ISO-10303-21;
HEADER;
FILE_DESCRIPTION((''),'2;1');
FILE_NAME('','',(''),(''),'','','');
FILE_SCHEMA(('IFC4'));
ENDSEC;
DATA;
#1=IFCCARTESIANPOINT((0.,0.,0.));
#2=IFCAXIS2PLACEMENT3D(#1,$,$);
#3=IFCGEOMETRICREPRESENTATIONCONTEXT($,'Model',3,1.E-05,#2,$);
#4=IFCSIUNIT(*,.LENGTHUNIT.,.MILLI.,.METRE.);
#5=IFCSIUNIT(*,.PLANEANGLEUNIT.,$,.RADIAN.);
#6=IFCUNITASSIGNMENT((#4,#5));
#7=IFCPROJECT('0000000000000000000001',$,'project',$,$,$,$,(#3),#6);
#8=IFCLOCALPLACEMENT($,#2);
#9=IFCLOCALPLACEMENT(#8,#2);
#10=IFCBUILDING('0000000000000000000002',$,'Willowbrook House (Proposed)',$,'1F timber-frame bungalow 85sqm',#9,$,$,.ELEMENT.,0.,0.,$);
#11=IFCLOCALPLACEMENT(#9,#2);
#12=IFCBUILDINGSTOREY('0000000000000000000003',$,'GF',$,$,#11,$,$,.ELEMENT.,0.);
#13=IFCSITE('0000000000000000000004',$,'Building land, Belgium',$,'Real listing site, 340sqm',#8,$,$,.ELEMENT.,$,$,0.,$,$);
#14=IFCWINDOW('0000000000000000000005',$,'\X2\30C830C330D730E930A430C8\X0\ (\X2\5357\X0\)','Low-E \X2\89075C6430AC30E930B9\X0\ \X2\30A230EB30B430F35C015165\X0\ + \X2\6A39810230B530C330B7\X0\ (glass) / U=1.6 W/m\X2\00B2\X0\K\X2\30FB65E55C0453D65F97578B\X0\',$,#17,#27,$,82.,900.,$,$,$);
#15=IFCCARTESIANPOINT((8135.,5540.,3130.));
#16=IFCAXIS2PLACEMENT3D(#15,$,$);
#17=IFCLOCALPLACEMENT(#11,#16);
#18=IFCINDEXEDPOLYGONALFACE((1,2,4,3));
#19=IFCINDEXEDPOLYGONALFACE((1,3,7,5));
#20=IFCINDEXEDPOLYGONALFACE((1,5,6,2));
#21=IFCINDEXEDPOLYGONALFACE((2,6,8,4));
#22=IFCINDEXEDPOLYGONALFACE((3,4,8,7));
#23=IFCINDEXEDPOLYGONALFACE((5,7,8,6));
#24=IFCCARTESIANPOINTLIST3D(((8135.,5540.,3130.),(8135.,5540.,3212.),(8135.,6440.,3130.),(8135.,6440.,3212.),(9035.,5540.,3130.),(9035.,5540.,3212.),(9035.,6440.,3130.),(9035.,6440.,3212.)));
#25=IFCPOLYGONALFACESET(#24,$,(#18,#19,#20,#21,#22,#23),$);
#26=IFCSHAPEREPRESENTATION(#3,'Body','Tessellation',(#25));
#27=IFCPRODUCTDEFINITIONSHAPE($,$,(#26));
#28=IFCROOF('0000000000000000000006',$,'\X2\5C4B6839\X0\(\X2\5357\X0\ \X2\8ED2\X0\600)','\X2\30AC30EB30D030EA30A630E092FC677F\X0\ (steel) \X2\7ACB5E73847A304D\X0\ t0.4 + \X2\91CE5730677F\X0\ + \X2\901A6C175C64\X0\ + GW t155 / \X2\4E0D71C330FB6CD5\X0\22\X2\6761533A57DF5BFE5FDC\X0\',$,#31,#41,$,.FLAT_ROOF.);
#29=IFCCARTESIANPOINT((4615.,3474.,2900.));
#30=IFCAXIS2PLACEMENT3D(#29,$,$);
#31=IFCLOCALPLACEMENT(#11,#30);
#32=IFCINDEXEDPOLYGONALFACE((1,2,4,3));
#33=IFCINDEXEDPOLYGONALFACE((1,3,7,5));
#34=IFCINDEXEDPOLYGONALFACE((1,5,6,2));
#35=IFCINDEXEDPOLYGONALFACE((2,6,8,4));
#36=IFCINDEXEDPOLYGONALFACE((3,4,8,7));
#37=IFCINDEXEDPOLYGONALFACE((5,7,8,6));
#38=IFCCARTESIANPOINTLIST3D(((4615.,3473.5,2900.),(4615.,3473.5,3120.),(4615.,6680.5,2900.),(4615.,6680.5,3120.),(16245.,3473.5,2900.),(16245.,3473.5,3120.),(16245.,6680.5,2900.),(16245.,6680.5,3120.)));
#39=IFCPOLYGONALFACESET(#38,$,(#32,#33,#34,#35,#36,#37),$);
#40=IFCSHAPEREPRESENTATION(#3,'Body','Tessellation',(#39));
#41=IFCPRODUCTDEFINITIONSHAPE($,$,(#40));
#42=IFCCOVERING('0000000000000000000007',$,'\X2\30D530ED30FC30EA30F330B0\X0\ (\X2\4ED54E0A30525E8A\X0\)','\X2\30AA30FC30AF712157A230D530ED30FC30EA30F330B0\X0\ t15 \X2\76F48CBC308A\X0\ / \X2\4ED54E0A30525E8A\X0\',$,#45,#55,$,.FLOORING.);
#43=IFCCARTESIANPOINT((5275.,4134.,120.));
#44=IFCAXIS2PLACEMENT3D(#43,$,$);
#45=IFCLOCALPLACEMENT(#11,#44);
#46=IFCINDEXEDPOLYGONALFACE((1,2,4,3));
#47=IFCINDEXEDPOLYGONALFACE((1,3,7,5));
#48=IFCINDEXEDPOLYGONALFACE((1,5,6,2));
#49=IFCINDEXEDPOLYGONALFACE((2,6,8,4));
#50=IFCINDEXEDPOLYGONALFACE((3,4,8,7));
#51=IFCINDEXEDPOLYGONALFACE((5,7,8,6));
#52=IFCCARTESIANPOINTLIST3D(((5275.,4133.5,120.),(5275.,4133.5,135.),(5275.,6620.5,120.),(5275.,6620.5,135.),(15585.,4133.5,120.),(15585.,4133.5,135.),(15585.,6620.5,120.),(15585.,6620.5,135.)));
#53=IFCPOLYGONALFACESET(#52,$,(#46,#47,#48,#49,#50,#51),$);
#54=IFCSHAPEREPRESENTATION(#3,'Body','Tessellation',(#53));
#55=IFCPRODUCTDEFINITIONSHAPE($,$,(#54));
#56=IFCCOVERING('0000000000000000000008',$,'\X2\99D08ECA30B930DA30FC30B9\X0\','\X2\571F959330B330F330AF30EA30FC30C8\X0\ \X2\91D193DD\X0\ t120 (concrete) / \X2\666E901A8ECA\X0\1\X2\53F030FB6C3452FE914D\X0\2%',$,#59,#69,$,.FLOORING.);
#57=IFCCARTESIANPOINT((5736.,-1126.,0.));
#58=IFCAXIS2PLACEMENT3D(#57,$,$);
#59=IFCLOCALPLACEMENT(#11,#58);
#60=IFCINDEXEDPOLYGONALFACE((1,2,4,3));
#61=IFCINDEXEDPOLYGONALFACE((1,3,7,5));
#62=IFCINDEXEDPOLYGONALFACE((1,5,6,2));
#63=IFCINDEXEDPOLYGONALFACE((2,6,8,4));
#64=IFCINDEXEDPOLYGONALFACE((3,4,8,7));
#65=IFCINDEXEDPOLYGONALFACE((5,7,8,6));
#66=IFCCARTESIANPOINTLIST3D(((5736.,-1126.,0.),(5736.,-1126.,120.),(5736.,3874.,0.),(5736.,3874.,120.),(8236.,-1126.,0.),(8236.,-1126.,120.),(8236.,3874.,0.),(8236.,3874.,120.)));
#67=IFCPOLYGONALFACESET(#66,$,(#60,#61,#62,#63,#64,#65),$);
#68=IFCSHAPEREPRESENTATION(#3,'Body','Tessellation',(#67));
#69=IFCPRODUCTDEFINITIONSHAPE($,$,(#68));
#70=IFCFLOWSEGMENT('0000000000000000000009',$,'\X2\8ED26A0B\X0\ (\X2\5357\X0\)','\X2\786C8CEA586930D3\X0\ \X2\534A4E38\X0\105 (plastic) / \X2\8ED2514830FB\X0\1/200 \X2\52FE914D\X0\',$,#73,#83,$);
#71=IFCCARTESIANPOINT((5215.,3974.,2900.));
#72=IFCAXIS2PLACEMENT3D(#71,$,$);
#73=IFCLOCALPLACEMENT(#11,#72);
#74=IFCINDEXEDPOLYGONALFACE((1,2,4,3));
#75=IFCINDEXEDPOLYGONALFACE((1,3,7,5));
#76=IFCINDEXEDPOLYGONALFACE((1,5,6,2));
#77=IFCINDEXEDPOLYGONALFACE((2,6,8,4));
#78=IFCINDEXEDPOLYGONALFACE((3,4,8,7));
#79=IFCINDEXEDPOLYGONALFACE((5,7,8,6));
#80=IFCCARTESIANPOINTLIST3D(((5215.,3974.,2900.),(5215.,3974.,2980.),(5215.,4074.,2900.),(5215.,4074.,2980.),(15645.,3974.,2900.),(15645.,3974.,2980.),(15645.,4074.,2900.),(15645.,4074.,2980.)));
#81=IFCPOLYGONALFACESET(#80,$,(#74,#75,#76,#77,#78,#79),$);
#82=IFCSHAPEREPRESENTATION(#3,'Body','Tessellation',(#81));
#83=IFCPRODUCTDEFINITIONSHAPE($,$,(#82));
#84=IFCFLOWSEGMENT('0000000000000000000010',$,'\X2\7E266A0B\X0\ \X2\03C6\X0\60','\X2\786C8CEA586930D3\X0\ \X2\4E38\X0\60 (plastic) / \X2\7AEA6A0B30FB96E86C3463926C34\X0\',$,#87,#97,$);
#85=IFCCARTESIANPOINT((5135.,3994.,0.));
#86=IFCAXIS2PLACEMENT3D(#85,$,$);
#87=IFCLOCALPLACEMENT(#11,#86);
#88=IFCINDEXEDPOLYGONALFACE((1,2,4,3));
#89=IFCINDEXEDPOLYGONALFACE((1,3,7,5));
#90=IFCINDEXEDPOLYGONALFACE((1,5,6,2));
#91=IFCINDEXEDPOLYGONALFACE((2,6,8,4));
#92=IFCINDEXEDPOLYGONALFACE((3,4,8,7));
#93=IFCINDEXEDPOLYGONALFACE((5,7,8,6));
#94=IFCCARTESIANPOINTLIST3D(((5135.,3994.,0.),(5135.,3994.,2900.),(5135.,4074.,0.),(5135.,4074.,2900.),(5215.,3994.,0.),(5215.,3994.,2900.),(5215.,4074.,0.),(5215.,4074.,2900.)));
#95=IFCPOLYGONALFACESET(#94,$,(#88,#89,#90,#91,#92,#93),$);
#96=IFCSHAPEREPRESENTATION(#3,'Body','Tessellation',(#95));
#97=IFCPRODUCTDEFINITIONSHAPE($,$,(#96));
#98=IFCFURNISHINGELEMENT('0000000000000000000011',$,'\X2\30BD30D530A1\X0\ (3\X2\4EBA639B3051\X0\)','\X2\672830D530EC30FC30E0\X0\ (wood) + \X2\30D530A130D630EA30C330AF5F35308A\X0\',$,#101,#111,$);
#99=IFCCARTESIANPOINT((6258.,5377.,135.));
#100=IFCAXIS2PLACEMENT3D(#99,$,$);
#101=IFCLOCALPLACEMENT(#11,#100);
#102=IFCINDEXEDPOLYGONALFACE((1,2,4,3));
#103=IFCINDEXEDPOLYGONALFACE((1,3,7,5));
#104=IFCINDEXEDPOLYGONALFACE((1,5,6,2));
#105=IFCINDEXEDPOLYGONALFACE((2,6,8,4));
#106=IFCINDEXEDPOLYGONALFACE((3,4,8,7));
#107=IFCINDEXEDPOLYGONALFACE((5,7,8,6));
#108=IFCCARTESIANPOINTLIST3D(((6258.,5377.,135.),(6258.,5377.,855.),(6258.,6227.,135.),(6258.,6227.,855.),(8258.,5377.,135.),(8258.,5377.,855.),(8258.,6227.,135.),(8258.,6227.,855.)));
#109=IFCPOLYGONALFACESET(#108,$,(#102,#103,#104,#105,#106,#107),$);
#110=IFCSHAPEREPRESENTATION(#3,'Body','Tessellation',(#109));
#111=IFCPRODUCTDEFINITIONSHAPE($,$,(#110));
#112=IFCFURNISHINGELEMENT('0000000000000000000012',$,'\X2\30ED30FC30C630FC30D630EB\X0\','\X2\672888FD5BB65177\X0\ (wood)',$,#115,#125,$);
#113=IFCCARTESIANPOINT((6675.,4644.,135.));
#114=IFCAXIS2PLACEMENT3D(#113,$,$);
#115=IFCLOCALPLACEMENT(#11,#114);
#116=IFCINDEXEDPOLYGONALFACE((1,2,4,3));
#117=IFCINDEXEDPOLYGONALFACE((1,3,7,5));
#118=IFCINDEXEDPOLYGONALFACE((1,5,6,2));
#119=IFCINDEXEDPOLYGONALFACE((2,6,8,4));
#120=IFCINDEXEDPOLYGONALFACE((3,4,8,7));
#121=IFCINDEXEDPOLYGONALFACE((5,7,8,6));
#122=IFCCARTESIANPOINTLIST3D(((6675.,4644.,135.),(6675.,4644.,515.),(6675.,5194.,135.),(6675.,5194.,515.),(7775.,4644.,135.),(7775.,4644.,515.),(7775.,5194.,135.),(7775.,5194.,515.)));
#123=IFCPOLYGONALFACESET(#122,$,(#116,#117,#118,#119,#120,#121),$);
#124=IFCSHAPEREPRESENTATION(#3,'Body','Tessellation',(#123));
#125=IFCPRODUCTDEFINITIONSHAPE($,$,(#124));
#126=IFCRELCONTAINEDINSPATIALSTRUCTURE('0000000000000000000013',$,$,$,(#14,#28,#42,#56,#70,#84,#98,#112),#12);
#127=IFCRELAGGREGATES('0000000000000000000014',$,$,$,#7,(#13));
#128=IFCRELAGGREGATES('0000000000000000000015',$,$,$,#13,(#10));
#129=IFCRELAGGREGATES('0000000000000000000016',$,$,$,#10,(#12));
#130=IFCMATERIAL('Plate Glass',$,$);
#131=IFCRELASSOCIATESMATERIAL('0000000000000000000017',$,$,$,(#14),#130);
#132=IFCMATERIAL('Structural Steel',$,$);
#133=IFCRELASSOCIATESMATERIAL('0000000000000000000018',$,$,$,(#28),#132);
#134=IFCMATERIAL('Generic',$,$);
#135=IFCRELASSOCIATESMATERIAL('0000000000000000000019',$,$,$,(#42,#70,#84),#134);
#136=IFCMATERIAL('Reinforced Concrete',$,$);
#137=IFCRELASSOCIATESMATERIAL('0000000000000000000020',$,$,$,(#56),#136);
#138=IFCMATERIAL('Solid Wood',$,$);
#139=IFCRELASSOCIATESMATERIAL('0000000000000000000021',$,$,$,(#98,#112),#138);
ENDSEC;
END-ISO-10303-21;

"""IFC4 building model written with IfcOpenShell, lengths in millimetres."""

from ifc_helpers import new_model, si_unit, frame, frame_2d, origin, place, context, project, spatial, rectangle, extrude, material, element, save


model = new_model("IFC4")

# Units and contexts
model_context = context("Model", 3, precision=1e-05, world=origin())
ifc_project = project(units=[si_unit("LENGTHUNIT", "METRE", prefix="MILLI"), si_unit("PLANEANGLEUNIT", "RADIAN")], contexts=[model_context])

# Site, building, storey
site_placement = place(None, origin())
site = spatial("IfcSite", under=ifc_project, at=site_placement, Name="Building land, Belgium", ObjectType="Real listing site, 340sqm", CompositionType="ELEMENT", RefElevation=0.0)
building_placement = place(site_placement, origin())
building = spatial("IfcBuilding", under=site, at=building_placement, Name="Willowbrook House (Proposed)", ObjectType="1F timber-frame bungalow 85sqm", CompositionType="ELEMENT", ElevationOfRefHeight=0.0, ElevationOfTerrain=0.0)
storey_placement = place(building_placement, origin())
storey = spatial("IfcBuildingStorey", under=building, at=storey_placement, Name="GF", CompositionType="ELEMENT", Elevation=0.0)

# Shared definitions
ifc_material_1 = material(Name="Solid Wood")

# Shared definitions
ifc_material_2 = material(Name="Reinforced Concrete")

# Shared definitions
ifc_material_3 = material(Name="Plate Glass")

# Window
window_1_placement = place(storey_placement, frame((8135.0, 5540.0, 3130.0)))
element("IfcWindow", 1, at=window_1_placement, inside=storey, material=ifc_material_3, Name="トップライト (南)", Description="Low-E 複層ガラス アルゴン封入 + 樹脂サッシ (glass) / U=1.6 W/m²K・日射取得型", OverallHeight=82.0, OverallWidth=900.0, context=model_context, shape_type="SweptSolid", body=[
    extrude(rectangle(XDim=900.0, YDim=900.0, at=frame_2d((450.0, 450.0))), frame((8135.0, 5540.0, 3130.0)), (0.0, 0.0, 1.0), 82.0),
])

# Roof
ifc_material_4 = material(Name="Structural Steel")
roof_1_placement = place(storey_placement, frame((4615.0, 3474.0, 2900.0)))
element("IfcRoof", 2, at=roof_1_placement, inside=storey, material=ifc_material_4, Name="屋根(南 軒600)", Description="ガルバリウム鋼板 (steel) 立平葺き t0.4 + 野地板 + 通気層 + GW t155 / 不燃・法22条区域対応", PredefinedType="FLAT_ROOF", context=model_context, shape_type="SweptSolid", body=[
    extrude(rectangle(XDim=11630.0, YDim=3207.0, at=frame_2d((5815.0, 1603.0))), frame((4615.0, 3474.0, 2900.0)), (0.0, 0.0, 1.0), 220.0),
])

# Coverings
ifc_material_5 = material(Name="Generic")
covering_1_placement = place(storey_placement, frame((5275.0, 4134.0, 120.0)))
element("IfcCovering", 3, at=covering_1_placement, inside=storey, material=ifc_material_5, Name="フローリング (仕上げ床)", Description="オーク無垢フローリング t15 直貼り / 仕上げ床", PredefinedType="FLOORING", context=model_context, shape_type="SweptSolid", body=[
    extrude(rectangle(XDim=10310.0, YDim=2487.0, at=frame_2d((5155.0, 1243.0))), frame((5275.0, 4134.0, 120.0)), (0.0, 0.0, 1.0), 15.0),
])
covering_2_placement = place(storey_placement, frame((5736.0, -1126.0, 0.0)))
element("IfcCovering", 4, at=covering_2_placement, inside=storey, material=ifc_material_2, Name="駐車スペース", Description="土間コンクリート 金鏝 t120 (concrete) / 普通車1台・水勾配2%", PredefinedType="FLOORING", context=model_context, shape_type="SweptSolid", body=[
    extrude(rectangle(XDim=2500.0, YDim=5000.0, at=frame_2d((1250.0, 2500.0))), frame((5736.0, -1126.0, 0.0)), (0.0, 0.0, 1.0), 120.0),
])

# Flow segments
flow_segment_1_placement = place(storey_placement, frame((5215.0, 3974.0, 2900.0)))
element("IfcFlowSegment", 5, at=flow_segment_1_placement, inside=storey, material=ifc_material_5, Name="軒樋 (南)", Description="硬質塩ビ 半丸105 (plastic) / 軒先・1/200 勾配", context=model_context, shape_type="SweptSolid", body=[
    extrude(rectangle(XDim=10430.0, YDim=100.0, at=frame_2d((5215.0, 50.0))), frame((5215.0, 3974.0, 2900.0)), (0.0, 0.0, 1.0), 80.0),
])
flow_segment_2_placement = place(storey_placement, frame((5135.0, 3994.0, 0.0)))
element("IfcFlowSegment", 6, at=flow_segment_2_placement, inside=storey, material=ifc_material_5, Name="縦樋 φ60", Description="硬質塩ビ 丸60 (plastic) / 竪樋・雨水排水", context=model_context, shape_type="SweptSolid", body=[
    extrude(rectangle(XDim=80.0, YDim=80.0, at=frame_2d((40.0, 40.0))), frame((5135.0, 3994.0, 0.0)), (0.0, 0.0, 1.0), 2900.0),
])

# Furnishing elements
furnishing_1_placement = place(storey_placement, frame((6258.0, 5377.0, 135.0)))
element("IfcFurnishingElement", 7, at=furnishing_1_placement, inside=storey, material=ifc_material_1, Name="ソファ (3人掛け)", Description="木フレーム (wood) + ファブリック張り", context=model_context, shape_type="SweptSolid", body=[
    extrude(rectangle(XDim=2000.0, YDim=850.0, at=frame_2d((1000.0, 425.0))), frame((6258.0, 5377.0, 135.0)), (0.0, 0.0, 1.0), 720.0),
])
furnishing_2_placement = place(storey_placement, frame((6675.0, 4644.0, 135.0)))
element("IfcFurnishingElement", 8, at=furnishing_2_placement, inside=storey, material=ifc_material_1, Name="ローテーブル", Description="木製家具 (wood)", context=model_context, shape_type="SweptSolid", body=[
    extrude(rectangle(XDim=1100.0, YDim=550.0, at=frame_2d((550.0, 275.0))), frame((6675.0, 4644.0, 135.0)), (0.0, 0.0, 1.0), 380.0),
])

save(model, "model.ifc")
